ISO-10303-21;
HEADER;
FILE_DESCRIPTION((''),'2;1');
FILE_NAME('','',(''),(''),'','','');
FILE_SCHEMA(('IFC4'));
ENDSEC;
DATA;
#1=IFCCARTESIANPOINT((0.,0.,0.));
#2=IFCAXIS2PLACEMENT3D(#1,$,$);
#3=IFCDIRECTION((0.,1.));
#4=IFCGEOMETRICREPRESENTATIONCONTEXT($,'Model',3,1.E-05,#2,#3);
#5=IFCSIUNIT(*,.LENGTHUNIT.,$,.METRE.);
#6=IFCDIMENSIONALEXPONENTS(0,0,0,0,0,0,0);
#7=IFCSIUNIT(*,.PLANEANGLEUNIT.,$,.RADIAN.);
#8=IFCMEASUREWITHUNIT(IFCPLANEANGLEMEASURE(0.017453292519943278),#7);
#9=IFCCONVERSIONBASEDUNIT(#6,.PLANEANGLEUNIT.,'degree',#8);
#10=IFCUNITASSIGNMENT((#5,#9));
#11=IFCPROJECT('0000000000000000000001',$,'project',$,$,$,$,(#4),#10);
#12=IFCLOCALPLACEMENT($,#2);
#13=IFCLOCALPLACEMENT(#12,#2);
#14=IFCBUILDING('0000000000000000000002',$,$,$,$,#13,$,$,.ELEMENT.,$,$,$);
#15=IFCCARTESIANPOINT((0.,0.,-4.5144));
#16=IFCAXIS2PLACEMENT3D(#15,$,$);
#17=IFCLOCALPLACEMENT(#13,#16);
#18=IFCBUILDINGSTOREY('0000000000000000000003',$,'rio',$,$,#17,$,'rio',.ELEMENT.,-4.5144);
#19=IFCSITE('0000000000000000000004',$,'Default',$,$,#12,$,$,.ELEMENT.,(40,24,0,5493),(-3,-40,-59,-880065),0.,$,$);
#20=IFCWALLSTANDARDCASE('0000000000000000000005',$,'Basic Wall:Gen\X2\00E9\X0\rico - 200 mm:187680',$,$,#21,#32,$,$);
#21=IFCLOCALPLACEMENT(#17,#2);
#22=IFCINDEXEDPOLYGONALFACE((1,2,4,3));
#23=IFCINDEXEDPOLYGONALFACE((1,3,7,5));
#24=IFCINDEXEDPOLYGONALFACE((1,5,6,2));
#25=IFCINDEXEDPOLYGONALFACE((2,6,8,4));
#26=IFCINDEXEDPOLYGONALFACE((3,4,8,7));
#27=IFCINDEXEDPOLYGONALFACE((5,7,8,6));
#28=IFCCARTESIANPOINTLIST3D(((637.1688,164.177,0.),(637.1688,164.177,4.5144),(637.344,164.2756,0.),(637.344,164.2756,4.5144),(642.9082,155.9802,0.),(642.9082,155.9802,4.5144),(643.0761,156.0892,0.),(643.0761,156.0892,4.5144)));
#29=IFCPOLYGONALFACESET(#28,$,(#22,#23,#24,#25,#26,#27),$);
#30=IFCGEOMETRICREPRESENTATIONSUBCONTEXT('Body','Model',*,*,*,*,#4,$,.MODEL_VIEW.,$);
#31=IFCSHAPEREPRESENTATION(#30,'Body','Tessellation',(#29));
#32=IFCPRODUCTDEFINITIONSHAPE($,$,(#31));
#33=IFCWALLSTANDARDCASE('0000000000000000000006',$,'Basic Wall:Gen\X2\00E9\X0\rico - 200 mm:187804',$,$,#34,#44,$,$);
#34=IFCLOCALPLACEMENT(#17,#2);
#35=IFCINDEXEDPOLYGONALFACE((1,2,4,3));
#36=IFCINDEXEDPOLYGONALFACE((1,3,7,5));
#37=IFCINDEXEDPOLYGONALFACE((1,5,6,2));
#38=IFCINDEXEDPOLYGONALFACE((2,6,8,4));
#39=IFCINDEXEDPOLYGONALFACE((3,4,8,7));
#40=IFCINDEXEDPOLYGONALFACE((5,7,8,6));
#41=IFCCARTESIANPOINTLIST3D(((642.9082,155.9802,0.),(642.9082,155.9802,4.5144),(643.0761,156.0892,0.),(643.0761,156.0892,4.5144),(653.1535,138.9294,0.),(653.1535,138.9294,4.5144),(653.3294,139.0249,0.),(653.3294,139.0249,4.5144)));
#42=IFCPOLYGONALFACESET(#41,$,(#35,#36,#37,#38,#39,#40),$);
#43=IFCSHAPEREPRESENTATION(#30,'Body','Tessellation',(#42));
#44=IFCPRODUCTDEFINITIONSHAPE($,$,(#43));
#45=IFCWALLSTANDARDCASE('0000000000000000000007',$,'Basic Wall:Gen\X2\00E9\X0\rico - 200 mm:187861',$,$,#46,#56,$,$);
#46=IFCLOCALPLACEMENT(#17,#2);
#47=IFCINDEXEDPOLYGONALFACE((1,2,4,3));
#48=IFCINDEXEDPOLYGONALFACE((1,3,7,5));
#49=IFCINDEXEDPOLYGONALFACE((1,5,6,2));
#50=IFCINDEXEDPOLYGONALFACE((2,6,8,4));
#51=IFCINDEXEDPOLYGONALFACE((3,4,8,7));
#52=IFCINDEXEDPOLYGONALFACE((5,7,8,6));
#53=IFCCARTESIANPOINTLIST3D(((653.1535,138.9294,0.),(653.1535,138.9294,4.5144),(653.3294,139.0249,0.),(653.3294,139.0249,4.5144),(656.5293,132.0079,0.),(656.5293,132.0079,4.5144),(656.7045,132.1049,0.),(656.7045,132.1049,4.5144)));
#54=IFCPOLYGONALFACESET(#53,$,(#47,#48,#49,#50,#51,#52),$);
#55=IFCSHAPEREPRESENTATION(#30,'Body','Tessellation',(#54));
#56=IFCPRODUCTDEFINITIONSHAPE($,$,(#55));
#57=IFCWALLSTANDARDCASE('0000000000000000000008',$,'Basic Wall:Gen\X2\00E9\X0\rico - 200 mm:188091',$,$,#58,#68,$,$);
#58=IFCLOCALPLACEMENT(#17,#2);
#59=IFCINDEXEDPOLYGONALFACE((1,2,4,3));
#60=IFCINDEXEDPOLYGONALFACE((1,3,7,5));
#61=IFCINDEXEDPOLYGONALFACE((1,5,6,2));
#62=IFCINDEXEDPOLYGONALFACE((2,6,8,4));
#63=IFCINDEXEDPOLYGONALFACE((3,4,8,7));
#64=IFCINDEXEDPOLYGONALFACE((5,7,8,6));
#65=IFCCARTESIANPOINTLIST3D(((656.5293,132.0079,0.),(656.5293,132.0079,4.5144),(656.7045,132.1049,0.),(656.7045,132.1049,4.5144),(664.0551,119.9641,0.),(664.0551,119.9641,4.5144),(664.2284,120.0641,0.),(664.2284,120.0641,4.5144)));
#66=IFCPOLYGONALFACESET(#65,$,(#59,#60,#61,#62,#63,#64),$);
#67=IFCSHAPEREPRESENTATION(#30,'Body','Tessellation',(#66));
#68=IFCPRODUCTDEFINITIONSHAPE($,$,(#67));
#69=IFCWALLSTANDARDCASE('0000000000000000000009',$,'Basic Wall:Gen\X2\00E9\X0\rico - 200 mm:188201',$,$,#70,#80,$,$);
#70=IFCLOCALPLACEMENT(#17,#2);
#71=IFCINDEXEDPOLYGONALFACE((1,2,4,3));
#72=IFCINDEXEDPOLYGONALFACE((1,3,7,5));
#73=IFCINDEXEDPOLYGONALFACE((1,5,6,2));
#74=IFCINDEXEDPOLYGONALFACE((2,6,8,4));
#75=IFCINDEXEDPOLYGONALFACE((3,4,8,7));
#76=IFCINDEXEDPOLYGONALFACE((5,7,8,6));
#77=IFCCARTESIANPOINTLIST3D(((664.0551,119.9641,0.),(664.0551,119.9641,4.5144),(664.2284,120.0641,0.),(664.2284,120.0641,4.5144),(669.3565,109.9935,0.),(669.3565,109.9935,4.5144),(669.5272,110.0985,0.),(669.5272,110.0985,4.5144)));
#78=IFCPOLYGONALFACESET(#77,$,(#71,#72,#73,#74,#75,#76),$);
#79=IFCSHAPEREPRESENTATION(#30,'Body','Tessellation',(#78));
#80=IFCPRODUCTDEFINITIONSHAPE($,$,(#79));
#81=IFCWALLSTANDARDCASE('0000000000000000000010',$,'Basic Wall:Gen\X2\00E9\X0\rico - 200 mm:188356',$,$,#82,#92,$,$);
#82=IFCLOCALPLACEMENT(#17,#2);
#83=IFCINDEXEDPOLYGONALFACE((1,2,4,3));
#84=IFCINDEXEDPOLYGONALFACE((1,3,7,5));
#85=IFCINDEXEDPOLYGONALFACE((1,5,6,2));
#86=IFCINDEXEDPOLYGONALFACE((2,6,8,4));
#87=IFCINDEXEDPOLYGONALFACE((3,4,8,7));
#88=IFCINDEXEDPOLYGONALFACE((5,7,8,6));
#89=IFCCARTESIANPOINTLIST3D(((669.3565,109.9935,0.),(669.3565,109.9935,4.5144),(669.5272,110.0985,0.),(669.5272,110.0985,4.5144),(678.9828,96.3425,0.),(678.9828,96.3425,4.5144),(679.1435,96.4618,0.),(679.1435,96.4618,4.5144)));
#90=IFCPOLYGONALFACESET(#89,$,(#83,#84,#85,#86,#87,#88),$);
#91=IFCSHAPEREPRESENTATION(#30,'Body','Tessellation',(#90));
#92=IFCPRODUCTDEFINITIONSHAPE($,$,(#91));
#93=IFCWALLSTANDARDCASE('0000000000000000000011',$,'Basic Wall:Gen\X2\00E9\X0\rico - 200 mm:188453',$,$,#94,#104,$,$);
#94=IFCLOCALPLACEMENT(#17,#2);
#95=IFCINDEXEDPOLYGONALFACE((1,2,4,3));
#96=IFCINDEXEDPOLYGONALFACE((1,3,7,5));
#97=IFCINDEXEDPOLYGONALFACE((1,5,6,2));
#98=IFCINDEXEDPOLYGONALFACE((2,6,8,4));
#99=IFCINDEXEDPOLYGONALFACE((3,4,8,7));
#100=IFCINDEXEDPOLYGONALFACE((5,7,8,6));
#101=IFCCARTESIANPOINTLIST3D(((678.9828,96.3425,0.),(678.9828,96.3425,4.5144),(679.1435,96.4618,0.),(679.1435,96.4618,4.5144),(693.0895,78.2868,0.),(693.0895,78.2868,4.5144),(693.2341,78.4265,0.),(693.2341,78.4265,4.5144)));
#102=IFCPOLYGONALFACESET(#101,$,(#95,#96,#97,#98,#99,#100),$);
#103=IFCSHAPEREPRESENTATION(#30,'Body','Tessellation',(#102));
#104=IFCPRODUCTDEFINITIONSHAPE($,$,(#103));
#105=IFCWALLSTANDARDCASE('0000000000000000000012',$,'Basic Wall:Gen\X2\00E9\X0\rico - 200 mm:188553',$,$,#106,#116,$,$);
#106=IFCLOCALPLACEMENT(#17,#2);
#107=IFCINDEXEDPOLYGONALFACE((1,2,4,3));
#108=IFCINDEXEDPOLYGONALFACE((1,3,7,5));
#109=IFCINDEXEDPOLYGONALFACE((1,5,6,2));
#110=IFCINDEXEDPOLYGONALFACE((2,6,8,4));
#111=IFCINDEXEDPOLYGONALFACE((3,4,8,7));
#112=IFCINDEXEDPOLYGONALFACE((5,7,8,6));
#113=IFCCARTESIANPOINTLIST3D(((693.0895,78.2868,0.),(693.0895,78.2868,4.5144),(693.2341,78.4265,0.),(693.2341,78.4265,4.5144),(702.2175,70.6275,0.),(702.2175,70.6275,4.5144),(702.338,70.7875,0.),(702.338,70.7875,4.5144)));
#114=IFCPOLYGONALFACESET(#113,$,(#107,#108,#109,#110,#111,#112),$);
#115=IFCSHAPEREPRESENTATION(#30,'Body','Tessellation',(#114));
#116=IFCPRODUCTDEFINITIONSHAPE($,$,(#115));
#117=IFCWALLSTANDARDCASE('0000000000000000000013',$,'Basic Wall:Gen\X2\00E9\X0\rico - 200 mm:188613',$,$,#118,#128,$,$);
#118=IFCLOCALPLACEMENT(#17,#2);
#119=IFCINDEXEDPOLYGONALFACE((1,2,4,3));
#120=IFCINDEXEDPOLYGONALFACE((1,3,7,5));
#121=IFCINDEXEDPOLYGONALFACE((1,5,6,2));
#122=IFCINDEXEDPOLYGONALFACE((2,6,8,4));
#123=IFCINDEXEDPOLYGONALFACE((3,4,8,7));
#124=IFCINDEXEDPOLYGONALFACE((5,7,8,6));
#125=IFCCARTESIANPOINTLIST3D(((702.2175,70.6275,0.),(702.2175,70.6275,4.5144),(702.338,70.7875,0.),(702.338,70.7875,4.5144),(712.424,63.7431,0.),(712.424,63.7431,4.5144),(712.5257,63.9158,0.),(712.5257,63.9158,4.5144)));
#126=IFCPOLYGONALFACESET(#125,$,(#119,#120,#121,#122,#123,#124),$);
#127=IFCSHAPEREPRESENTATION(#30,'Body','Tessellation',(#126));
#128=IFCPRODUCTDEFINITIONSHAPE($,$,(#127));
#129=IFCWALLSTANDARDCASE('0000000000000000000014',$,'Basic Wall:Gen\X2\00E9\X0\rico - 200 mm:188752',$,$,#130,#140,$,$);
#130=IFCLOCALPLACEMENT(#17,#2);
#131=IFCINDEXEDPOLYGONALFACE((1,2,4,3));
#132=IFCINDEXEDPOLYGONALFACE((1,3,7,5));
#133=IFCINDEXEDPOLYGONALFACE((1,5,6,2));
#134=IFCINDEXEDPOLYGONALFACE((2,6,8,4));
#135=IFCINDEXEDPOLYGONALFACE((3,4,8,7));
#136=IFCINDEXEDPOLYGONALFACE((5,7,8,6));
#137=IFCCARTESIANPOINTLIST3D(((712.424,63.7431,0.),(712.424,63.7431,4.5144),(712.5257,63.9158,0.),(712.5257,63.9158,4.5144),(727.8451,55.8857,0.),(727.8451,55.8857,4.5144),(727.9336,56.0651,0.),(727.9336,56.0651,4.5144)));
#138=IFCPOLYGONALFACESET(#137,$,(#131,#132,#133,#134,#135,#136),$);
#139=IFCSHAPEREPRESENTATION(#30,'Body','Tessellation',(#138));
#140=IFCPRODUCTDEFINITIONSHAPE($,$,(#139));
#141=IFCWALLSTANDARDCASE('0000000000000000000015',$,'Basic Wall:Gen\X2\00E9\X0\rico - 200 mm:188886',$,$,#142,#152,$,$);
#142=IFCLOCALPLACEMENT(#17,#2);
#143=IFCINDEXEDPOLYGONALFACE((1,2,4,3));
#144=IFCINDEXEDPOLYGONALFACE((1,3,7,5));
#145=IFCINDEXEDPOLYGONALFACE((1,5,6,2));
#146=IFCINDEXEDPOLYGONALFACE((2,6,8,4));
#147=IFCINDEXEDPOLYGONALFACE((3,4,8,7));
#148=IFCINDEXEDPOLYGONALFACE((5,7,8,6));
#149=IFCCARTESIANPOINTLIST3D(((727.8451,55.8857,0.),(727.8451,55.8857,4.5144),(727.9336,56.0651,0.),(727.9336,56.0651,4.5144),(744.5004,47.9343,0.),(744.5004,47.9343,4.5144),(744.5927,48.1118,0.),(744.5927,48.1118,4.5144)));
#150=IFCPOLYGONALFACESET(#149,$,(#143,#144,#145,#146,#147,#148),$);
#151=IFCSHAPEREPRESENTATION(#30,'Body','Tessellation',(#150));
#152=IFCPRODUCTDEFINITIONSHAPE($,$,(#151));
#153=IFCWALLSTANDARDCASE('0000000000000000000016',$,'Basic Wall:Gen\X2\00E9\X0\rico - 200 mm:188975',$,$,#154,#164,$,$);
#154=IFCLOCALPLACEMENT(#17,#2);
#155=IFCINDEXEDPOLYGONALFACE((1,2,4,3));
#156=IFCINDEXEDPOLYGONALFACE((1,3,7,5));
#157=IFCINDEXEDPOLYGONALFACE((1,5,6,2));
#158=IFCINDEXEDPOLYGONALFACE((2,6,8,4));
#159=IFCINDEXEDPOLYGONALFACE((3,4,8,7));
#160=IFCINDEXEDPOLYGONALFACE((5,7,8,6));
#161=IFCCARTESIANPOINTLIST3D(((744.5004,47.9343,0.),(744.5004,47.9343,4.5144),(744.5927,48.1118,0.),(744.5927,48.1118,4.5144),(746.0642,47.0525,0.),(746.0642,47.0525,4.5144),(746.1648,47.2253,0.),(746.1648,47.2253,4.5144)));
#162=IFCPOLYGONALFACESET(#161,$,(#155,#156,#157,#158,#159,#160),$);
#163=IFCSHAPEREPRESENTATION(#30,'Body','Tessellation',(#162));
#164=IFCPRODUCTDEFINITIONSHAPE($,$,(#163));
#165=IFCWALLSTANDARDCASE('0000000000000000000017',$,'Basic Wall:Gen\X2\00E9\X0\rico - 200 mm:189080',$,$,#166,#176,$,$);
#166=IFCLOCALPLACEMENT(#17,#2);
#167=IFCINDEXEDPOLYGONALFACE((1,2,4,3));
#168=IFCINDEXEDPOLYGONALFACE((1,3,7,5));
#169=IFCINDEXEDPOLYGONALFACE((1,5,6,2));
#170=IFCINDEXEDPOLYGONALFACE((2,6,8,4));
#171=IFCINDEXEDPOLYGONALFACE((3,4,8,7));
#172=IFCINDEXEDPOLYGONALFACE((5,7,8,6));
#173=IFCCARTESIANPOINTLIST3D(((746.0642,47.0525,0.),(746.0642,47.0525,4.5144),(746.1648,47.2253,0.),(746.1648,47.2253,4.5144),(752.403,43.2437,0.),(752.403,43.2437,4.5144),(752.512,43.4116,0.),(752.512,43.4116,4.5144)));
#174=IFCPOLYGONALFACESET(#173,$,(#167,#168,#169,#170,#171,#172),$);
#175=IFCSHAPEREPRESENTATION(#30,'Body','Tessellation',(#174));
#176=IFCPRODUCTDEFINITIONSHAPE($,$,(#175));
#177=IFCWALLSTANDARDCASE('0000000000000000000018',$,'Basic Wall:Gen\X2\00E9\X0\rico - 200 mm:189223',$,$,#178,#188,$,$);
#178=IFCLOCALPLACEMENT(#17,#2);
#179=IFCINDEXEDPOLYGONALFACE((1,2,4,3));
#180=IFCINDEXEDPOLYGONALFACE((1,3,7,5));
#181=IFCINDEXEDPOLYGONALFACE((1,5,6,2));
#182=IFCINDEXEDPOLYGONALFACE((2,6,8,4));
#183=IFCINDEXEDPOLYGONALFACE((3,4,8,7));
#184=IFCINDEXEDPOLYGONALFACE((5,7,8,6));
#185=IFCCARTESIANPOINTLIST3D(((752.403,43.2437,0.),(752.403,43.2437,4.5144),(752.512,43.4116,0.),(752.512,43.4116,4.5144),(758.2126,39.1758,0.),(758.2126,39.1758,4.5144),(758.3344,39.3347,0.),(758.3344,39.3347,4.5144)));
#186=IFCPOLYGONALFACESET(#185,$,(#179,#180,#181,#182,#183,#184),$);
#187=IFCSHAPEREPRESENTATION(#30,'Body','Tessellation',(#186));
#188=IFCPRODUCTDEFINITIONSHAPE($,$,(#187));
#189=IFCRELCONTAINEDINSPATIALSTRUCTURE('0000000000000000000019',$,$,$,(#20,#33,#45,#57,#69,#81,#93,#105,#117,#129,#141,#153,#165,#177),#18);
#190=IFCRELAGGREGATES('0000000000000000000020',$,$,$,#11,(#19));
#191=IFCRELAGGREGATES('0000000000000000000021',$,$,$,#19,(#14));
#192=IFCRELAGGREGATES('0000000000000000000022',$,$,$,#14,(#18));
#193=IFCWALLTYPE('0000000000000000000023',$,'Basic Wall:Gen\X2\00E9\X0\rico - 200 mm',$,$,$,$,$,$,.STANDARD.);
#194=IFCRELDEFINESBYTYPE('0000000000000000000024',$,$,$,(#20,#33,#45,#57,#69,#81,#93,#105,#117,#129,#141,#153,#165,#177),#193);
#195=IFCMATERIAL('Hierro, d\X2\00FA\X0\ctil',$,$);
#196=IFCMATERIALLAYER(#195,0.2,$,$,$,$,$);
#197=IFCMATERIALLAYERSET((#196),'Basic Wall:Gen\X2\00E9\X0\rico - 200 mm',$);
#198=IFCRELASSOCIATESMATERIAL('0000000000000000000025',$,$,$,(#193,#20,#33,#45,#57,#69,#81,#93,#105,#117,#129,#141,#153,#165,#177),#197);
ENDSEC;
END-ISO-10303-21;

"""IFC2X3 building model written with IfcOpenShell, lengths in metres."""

from ifc_helpers import new_model, entity, si_unit, converted_unit, direction, frame, origin, place, context, subcontext, project, spatial, polyline, outline, extrude, material, layer, layer_set, layer_usage, type_object, element, save


model = new_model("IFC2X3")

# Units and contexts
model_context = context("Model", 3, precision=1e-05, world=origin(), true_north=direction((0.0, 1.0)))
body_context = subcontext(model_context, "Body", "Model", "MODEL_VIEW")
ifc_project = project(units=[si_unit("LENGTHUNIT", "METRE"), converted_unit("PLANEANGLEUNIT", "degree", entity("IfcPlaneAngleMeasure", 0.017453292519943278), si_unit("PLANEANGLEUNIT", "RADIAN"), dimensions=[0, 0, 0, 0, 0, 0, 0])], contexts=[model_context])

# Site, building, storey
site_placement = place(None, origin())
site = spatial("IfcSite", under=ifc_project, at=site_placement, Name="Default", CompositionType="ELEMENT", RefLatitude=(40, 24, 0, 5493), RefLongitude=(-3, -40, -59, -880065), RefElevation=0.0)
building_placement = place(site_placement, origin())
building = spatial("IfcBuilding", under=site, at=building_placement, CompositionType="ELEMENT")
storey_placement = place(building_placement, frame((0.0, 0.0, -4.5144)))
storey = spatial("IfcBuildingStorey", under=building, at=storey_placement, Name="rio", LongName="rio", CompositionType="ELEMENT", Elevation=-4.5144)

# Walls
ifc_material = material(Name="Hierro, dúctil")
ifc_layer = layer(ifc_material, 0.2)
ifc_layer_set = layer_set([ifc_layer], Name="Basic Wall:Genérico - 200 mm")
ifc_layer_usage_1 = layer_usage(ifc_layer_set, "AXIS2", "NEGATIVE", 0.1)
wall_type = type_object("IfcWallType", Name="Basic Wall:Genérico - 200 mm", PredefinedType="STANDARD", material=ifc_layer_set)
wall_1_placement = place(storey_placement, frame((637.2508, 164.2343, 0.0), z_axis=(0.0, 0.0, 1.0), x_axis=(0.573576, -0.819152, 0.0)))
element("IfcWallStandardCase", 1, at=wall_1_placement, inside=storey, type_object=wall_type, material=ifc_layer_usage_1, Name="Basic Wall:Genérico - 200 mm:187680", context=body_context, shape_type="SweptSolid", body=[
    extrude(outline(polyline([(10.0064, -0.1), (10.0133, 0.1), (0.0197, 0.1), (0.0, -0.1), (10.0064, -0.1)])), origin(), (0.0, 0.0, 1.0), 4.5144),
])
ifc_layer_usage_2 = layer_usage(ifc_layer_set, "AXIS2", "NEGATIVE", 0.1)
wall_2_placement = place(storey_placement, frame((642.9904, 156.0377, 0.0), z_axis=(0.0, 0.0, 1.0), x_axis=(0.515038, -0.857167, 0.0)))
element("IfcWallStandardCase", 2, at=wall_2_placement, inside=storey, type_object=wall_type, material=ifc_layer_usage_2, Name="Basic Wall:Genérico - 200 mm:187804", context=body_context, shape_type="SweptSolid", body=[
    extrude(outline(polyline([(19.8991, -0.1), (19.9079, 0.1), (0.0, 0.1), (0.007, -0.1), (19.8991, -0.1)])), origin(), (0.0, 0.0, 1.0), 4.5144),
])
ifc_layer_usage_3 = layer_usage(ifc_layer_set, "AXIS2", "NEGATIVE", 0.1)
wall_3_placement = place(storey_placement, frame((653.2395, 138.981, 0.0), z_axis=(0.0, 0.0, 1.0), x_axis=(0.438371, -0.898794, 0.0)))
element("IfcWallStandardCase", 3, at=wall_3_placement, inside=storey, type_object=wall_type, material=ifc_layer_usage_3, Name="Basic Wall:Genérico - 200 mm:187861", context=body_context, shape_type="SweptSolid", body=[
    extrude(outline(polyline([(7.7096, -0.1), (7.6991, 0.1), (0.0, 0.1), (0.0087, -0.1), (7.7096, -0.1)])), origin(), (0.0, 0.0, 1.0), 4.5144),
])
ifc_layer_usage_4 = layer_usage(ifc_layer_set, "AXIS2", "NEGATIVE", 0.1)
wall_4_placement = place(storey_placement, frame((656.6141, 132.0608, 0.0), z_axis=(0.0, 0.0, 1.0), x_axis=(0.529919, -0.848048, 0.0)))
element("IfcWallStandardCase", 4, at=wall_4_placement, inside=storey, type_object=wall_type, material=ifc_layer_usage_4, Name="Basic Wall:Genérico - 200 mm:188091", context=body_context, shape_type="SweptSolid", body=[
    extrude(outline(polyline([(14.2017, -0.1), (14.2087, 0.1), (0.0105, 0.1), (0.0, -0.1), (14.2017, -0.1)])), origin(), (0.0, 0.0, 1.0), 4.5144),
])
ifc_layer_usage_5 = layer_usage(ifc_layer_set, "AXIS2", "NEGATIVE", 0.1)
wall_5_placement = place(storey_placement, frame((664.1401, 120.0172, 0.0), z_axis=(0.0, 0.0, 1.0), x_axis=(0.469472, -0.882948, 0.0)))
element("IfcWallStandardCase", 5, at=wall_5_placement, inside=storey, type_object=wall_type, material=ifc_layer_usage_5, Name="Basic Wall:Genérico - 200 mm:188201", context=body_context, shape_type="SweptSolid", body=[
    extrude(outline(polyline([(11.2994, -0.1), (11.2868, 0.1), (0.0, 0.1), (0.007, -0.1), (11.2994, -0.1)])), origin(), (0.0, 0.0, 1.0), 4.5144),
])
ifc_layer_usage_6 = layer_usage(ifc_layer_set, "AXIS2", "NEGATIVE", 0.1)
wall_6_placement = place(storey_placement, frame((669.4383, 110.0511, 0.0), z_axis=(0.0, 0.0, 1.0), x_axis=(0.576296, -0.817241, 0.0)))
element("IfcWallStandardCase", 6, at=wall_6_placement, inside=storey, type_object=wall_type, material=ifc_layer_usage_6, Name="Basic Wall:Genérico - 200 mm:188356", context=body_context, shape_type="SweptSolid", body=[
    extrude(outline(polyline([(16.7038, -0.1), (16.6989, 0.1), (0.0126, 0.1), (0.0, -0.1), (16.7038, -0.1)])), origin(), (0.0, 0.0, 1.0), 4.5144),
])
ifc_layer_usage_7 = layer_usage(ifc_layer_set, "AXIS2", "NEGATIVE", 0.1)
wall_7_placement = place(storey_placement, frame((679.0616, 96.4041, 0.0), z_axis=(0.0, 0.0, 1.0), x_axis=(0.615661, -0.788011, 0.0)))
element("IfcWallStandardCase", 7, at=wall_7_placement, inside=storey, type_object=wall_type, material=ifc_layer_usage_7, Name="Basic Wall:Genérico - 200 mm:188453", context=body_context, shape_type="SweptSolid", body=[
    extrude(outline(polyline([(22.913, -0.1), (22.8919, 0.1), (0.0049, 0.1), (0.0, -0.1), (22.913, -0.1)])), origin(), (0.0, 0.0, 1.0), 4.5144),
])
ifc_layer_usage_8 = layer_usage(ifc_layer_set, "AXIS2", "NEGATIVE", 0.1)
wall_8_placement = place(storey_placement, frame((693.1537, 78.3634, 0.0), z_axis=(0.0, 0.0, 1.0), x_axis=(0.766044, -0.642788, 0.0)))
element("IfcWallStandardCase", 8, at=wall_8_placement, inside=storey, type_object=wall_type, material=ifc_layer_usage_8, Name="Basic Wall:Genérico - 200 mm:188553", context=body_context, shape_type="SweptSolid", body=[
    extrude(outline(polyline([(11.9158, -0.1), (11.9053, 0.1), (0.021, 0.1), (0.0, -0.1), (11.9158, -0.1)])), origin(), (0.0, 0.0, 1.0), 4.5144),
])
ifc_layer_usage_9 = layer_usage(ifc_layer_set, "AXIS2", "NEGATIVE", 0.1)
wall_9_placement = place(storey_placement, frame((702.2734, 70.7104, 0.0), z_axis=(0.0, 0.0, 1.0), x_axis=(0.829038, -0.559193, 0.0)))
element("IfcWallStandardCase", 9, at=wall_9_placement, inside=storey, type_object=wall_type, material=ifc_layer_usage_9, Name="Basic Wall:Genérico - 200 mm:188613", context=body_context, shape_type="SweptSolid", body=[
    extrude(outline(polyline([(12.3114, -0.1), (12.2991, 0.1), (0.0105, 0.1), (0.0, -0.1), (12.3114, -0.1)])), origin(), (0.0, 0.0, 1.0), 4.5144),
])
ifc_layer_usage_10 = layer_usage(ifc_layer_set, "AXIS2", "NEGATIVE", 0.1)
wall_10_placement = place(storey_placement, frame((712.4694, 63.8322, 0.0), z_axis=(0.0, 0.0, 1.0), x_axis=(0.891007, -0.45399, 0.0)))
element("IfcWallStandardCase", 10, at=wall_10_placement, inside=storey, type_object=wall_type, material=ifc_layer_usage_10, Name="Basic Wall:Genérico - 200 mm:188752", context=body_context, shape_type="SweptSolid", body=[
    extrude(outline(polyline([(17.3074, -0.1), (17.3048, 0.1), (0.0122, 0.1), (0.0, -0.1), (17.3074, -0.1)])), origin(), (0.0, 0.0, 1.0), 4.5144),
])
ifc_layer_usage_11 = layer_usage(ifc_layer_set, "AXIS2", "NEGATIVE", 0.1)
wall_11_placement = place(storey_placement, frame((727.8881, 55.9759, 0.0), z_axis=(0.0, 0.0, 1.0), x_axis=(0.902433, -0.43083, 0.0)))
element("IfcWallStandardCase", 11, at=wall_11_placement, inside=storey, type_object=wall_type, material=ifc_layer_usage_11, Name="Basic Wall:Genérico - 200 mm:188886", context=body_context, shape_type="SweptSolid", body=[
    extrude(outline(polyline([(18.4561, -0.1), (18.4629, 0.1), (0.0026, 0.1), (0.0, -0.1), (18.4561, -0.1)])), origin(), (0.0, 0.0, 1.0), 4.5144),
])
ifc_layer_usage_12 = layer_usage(ifc_layer_set, "AXIS2", "NEGATIVE", 0.1)
wall_12_placement = place(storey_placement, frame((744.5436, 48.0247, 0.0), z_axis=(0.0, 0.0, 1.0), x_axis=(0.871054, -0.491187, 0.0)))
element("IfcWallStandardCase", 12, at=wall_12_placement, inside=storey, type_object=wall_type, material=ifc_layer_usage_12, Name="Basic Wall:Genérico - 200 mm:188975", context=body_context, shape_type="SweptSolid", body=[
    extrude(outline(polyline([(1.802, -0.1), (1.8048, 0.1), (0.0, 0.1), (0.0068, -0.1), (1.802, -0.1)])), origin(), (0.0, 0.0, 1.0), 4.5144),
])
ifc_layer_usage_13 = layer_usage(ifc_layer_set, "AXIS2", "NEGATIVE", 0.1)
wall_13_placement = place(storey_placement, frame((746.1133, 47.1396, 0.0), z_axis=(0.0, 0.0, 1.0), x_axis=(0.857167, -0.515038, 0.0)))
element("IfcWallStandardCase", 13, at=wall_13_placement, inside=storey, type_object=wall_type, material=ifc_layer_usage_13, Name="Basic Wall:Genérico - 200 mm:189080", context=body_context, shape_type="SweptSolid", body=[
    extrude(outline(polyline([(7.3979, -0.1), (7.4049, 0.1), (0.0, 0.1), (0.0028, -0.1), (7.3979, -0.1)])), origin(), (0.0, 0.0, 1.0), 4.5144),
])
ifc_layer_usage_14 = layer_usage(ifc_layer_set, "AXIS2", "NEGATIVE", 0.1)
wall_14_placement = place(storey_placement, frame((752.4547, 43.3296, 0.0), z_axis=(0.0, 0.0, 1.0), x_axis=(0.819152, -0.573576, 0.0)))
element("IfcWallStandardCase", 14, at=wall_14_placement, inside=storey, type_object=wall_type, material=ifc_layer_usage_14, Name="Basic Wall:Genérico - 200 mm:189223", context=body_context, shape_type="SweptSolid", body=[
    extrude(outline(polyline([(7.0991, -0.1), (7.1079, 0.1), (0.0, 0.1), (0.007, -0.1), (7.0991, -0.1)])), origin(), (0.0, 0.0, 1.0), 4.5144),
])

save(model, "model.ifc")
